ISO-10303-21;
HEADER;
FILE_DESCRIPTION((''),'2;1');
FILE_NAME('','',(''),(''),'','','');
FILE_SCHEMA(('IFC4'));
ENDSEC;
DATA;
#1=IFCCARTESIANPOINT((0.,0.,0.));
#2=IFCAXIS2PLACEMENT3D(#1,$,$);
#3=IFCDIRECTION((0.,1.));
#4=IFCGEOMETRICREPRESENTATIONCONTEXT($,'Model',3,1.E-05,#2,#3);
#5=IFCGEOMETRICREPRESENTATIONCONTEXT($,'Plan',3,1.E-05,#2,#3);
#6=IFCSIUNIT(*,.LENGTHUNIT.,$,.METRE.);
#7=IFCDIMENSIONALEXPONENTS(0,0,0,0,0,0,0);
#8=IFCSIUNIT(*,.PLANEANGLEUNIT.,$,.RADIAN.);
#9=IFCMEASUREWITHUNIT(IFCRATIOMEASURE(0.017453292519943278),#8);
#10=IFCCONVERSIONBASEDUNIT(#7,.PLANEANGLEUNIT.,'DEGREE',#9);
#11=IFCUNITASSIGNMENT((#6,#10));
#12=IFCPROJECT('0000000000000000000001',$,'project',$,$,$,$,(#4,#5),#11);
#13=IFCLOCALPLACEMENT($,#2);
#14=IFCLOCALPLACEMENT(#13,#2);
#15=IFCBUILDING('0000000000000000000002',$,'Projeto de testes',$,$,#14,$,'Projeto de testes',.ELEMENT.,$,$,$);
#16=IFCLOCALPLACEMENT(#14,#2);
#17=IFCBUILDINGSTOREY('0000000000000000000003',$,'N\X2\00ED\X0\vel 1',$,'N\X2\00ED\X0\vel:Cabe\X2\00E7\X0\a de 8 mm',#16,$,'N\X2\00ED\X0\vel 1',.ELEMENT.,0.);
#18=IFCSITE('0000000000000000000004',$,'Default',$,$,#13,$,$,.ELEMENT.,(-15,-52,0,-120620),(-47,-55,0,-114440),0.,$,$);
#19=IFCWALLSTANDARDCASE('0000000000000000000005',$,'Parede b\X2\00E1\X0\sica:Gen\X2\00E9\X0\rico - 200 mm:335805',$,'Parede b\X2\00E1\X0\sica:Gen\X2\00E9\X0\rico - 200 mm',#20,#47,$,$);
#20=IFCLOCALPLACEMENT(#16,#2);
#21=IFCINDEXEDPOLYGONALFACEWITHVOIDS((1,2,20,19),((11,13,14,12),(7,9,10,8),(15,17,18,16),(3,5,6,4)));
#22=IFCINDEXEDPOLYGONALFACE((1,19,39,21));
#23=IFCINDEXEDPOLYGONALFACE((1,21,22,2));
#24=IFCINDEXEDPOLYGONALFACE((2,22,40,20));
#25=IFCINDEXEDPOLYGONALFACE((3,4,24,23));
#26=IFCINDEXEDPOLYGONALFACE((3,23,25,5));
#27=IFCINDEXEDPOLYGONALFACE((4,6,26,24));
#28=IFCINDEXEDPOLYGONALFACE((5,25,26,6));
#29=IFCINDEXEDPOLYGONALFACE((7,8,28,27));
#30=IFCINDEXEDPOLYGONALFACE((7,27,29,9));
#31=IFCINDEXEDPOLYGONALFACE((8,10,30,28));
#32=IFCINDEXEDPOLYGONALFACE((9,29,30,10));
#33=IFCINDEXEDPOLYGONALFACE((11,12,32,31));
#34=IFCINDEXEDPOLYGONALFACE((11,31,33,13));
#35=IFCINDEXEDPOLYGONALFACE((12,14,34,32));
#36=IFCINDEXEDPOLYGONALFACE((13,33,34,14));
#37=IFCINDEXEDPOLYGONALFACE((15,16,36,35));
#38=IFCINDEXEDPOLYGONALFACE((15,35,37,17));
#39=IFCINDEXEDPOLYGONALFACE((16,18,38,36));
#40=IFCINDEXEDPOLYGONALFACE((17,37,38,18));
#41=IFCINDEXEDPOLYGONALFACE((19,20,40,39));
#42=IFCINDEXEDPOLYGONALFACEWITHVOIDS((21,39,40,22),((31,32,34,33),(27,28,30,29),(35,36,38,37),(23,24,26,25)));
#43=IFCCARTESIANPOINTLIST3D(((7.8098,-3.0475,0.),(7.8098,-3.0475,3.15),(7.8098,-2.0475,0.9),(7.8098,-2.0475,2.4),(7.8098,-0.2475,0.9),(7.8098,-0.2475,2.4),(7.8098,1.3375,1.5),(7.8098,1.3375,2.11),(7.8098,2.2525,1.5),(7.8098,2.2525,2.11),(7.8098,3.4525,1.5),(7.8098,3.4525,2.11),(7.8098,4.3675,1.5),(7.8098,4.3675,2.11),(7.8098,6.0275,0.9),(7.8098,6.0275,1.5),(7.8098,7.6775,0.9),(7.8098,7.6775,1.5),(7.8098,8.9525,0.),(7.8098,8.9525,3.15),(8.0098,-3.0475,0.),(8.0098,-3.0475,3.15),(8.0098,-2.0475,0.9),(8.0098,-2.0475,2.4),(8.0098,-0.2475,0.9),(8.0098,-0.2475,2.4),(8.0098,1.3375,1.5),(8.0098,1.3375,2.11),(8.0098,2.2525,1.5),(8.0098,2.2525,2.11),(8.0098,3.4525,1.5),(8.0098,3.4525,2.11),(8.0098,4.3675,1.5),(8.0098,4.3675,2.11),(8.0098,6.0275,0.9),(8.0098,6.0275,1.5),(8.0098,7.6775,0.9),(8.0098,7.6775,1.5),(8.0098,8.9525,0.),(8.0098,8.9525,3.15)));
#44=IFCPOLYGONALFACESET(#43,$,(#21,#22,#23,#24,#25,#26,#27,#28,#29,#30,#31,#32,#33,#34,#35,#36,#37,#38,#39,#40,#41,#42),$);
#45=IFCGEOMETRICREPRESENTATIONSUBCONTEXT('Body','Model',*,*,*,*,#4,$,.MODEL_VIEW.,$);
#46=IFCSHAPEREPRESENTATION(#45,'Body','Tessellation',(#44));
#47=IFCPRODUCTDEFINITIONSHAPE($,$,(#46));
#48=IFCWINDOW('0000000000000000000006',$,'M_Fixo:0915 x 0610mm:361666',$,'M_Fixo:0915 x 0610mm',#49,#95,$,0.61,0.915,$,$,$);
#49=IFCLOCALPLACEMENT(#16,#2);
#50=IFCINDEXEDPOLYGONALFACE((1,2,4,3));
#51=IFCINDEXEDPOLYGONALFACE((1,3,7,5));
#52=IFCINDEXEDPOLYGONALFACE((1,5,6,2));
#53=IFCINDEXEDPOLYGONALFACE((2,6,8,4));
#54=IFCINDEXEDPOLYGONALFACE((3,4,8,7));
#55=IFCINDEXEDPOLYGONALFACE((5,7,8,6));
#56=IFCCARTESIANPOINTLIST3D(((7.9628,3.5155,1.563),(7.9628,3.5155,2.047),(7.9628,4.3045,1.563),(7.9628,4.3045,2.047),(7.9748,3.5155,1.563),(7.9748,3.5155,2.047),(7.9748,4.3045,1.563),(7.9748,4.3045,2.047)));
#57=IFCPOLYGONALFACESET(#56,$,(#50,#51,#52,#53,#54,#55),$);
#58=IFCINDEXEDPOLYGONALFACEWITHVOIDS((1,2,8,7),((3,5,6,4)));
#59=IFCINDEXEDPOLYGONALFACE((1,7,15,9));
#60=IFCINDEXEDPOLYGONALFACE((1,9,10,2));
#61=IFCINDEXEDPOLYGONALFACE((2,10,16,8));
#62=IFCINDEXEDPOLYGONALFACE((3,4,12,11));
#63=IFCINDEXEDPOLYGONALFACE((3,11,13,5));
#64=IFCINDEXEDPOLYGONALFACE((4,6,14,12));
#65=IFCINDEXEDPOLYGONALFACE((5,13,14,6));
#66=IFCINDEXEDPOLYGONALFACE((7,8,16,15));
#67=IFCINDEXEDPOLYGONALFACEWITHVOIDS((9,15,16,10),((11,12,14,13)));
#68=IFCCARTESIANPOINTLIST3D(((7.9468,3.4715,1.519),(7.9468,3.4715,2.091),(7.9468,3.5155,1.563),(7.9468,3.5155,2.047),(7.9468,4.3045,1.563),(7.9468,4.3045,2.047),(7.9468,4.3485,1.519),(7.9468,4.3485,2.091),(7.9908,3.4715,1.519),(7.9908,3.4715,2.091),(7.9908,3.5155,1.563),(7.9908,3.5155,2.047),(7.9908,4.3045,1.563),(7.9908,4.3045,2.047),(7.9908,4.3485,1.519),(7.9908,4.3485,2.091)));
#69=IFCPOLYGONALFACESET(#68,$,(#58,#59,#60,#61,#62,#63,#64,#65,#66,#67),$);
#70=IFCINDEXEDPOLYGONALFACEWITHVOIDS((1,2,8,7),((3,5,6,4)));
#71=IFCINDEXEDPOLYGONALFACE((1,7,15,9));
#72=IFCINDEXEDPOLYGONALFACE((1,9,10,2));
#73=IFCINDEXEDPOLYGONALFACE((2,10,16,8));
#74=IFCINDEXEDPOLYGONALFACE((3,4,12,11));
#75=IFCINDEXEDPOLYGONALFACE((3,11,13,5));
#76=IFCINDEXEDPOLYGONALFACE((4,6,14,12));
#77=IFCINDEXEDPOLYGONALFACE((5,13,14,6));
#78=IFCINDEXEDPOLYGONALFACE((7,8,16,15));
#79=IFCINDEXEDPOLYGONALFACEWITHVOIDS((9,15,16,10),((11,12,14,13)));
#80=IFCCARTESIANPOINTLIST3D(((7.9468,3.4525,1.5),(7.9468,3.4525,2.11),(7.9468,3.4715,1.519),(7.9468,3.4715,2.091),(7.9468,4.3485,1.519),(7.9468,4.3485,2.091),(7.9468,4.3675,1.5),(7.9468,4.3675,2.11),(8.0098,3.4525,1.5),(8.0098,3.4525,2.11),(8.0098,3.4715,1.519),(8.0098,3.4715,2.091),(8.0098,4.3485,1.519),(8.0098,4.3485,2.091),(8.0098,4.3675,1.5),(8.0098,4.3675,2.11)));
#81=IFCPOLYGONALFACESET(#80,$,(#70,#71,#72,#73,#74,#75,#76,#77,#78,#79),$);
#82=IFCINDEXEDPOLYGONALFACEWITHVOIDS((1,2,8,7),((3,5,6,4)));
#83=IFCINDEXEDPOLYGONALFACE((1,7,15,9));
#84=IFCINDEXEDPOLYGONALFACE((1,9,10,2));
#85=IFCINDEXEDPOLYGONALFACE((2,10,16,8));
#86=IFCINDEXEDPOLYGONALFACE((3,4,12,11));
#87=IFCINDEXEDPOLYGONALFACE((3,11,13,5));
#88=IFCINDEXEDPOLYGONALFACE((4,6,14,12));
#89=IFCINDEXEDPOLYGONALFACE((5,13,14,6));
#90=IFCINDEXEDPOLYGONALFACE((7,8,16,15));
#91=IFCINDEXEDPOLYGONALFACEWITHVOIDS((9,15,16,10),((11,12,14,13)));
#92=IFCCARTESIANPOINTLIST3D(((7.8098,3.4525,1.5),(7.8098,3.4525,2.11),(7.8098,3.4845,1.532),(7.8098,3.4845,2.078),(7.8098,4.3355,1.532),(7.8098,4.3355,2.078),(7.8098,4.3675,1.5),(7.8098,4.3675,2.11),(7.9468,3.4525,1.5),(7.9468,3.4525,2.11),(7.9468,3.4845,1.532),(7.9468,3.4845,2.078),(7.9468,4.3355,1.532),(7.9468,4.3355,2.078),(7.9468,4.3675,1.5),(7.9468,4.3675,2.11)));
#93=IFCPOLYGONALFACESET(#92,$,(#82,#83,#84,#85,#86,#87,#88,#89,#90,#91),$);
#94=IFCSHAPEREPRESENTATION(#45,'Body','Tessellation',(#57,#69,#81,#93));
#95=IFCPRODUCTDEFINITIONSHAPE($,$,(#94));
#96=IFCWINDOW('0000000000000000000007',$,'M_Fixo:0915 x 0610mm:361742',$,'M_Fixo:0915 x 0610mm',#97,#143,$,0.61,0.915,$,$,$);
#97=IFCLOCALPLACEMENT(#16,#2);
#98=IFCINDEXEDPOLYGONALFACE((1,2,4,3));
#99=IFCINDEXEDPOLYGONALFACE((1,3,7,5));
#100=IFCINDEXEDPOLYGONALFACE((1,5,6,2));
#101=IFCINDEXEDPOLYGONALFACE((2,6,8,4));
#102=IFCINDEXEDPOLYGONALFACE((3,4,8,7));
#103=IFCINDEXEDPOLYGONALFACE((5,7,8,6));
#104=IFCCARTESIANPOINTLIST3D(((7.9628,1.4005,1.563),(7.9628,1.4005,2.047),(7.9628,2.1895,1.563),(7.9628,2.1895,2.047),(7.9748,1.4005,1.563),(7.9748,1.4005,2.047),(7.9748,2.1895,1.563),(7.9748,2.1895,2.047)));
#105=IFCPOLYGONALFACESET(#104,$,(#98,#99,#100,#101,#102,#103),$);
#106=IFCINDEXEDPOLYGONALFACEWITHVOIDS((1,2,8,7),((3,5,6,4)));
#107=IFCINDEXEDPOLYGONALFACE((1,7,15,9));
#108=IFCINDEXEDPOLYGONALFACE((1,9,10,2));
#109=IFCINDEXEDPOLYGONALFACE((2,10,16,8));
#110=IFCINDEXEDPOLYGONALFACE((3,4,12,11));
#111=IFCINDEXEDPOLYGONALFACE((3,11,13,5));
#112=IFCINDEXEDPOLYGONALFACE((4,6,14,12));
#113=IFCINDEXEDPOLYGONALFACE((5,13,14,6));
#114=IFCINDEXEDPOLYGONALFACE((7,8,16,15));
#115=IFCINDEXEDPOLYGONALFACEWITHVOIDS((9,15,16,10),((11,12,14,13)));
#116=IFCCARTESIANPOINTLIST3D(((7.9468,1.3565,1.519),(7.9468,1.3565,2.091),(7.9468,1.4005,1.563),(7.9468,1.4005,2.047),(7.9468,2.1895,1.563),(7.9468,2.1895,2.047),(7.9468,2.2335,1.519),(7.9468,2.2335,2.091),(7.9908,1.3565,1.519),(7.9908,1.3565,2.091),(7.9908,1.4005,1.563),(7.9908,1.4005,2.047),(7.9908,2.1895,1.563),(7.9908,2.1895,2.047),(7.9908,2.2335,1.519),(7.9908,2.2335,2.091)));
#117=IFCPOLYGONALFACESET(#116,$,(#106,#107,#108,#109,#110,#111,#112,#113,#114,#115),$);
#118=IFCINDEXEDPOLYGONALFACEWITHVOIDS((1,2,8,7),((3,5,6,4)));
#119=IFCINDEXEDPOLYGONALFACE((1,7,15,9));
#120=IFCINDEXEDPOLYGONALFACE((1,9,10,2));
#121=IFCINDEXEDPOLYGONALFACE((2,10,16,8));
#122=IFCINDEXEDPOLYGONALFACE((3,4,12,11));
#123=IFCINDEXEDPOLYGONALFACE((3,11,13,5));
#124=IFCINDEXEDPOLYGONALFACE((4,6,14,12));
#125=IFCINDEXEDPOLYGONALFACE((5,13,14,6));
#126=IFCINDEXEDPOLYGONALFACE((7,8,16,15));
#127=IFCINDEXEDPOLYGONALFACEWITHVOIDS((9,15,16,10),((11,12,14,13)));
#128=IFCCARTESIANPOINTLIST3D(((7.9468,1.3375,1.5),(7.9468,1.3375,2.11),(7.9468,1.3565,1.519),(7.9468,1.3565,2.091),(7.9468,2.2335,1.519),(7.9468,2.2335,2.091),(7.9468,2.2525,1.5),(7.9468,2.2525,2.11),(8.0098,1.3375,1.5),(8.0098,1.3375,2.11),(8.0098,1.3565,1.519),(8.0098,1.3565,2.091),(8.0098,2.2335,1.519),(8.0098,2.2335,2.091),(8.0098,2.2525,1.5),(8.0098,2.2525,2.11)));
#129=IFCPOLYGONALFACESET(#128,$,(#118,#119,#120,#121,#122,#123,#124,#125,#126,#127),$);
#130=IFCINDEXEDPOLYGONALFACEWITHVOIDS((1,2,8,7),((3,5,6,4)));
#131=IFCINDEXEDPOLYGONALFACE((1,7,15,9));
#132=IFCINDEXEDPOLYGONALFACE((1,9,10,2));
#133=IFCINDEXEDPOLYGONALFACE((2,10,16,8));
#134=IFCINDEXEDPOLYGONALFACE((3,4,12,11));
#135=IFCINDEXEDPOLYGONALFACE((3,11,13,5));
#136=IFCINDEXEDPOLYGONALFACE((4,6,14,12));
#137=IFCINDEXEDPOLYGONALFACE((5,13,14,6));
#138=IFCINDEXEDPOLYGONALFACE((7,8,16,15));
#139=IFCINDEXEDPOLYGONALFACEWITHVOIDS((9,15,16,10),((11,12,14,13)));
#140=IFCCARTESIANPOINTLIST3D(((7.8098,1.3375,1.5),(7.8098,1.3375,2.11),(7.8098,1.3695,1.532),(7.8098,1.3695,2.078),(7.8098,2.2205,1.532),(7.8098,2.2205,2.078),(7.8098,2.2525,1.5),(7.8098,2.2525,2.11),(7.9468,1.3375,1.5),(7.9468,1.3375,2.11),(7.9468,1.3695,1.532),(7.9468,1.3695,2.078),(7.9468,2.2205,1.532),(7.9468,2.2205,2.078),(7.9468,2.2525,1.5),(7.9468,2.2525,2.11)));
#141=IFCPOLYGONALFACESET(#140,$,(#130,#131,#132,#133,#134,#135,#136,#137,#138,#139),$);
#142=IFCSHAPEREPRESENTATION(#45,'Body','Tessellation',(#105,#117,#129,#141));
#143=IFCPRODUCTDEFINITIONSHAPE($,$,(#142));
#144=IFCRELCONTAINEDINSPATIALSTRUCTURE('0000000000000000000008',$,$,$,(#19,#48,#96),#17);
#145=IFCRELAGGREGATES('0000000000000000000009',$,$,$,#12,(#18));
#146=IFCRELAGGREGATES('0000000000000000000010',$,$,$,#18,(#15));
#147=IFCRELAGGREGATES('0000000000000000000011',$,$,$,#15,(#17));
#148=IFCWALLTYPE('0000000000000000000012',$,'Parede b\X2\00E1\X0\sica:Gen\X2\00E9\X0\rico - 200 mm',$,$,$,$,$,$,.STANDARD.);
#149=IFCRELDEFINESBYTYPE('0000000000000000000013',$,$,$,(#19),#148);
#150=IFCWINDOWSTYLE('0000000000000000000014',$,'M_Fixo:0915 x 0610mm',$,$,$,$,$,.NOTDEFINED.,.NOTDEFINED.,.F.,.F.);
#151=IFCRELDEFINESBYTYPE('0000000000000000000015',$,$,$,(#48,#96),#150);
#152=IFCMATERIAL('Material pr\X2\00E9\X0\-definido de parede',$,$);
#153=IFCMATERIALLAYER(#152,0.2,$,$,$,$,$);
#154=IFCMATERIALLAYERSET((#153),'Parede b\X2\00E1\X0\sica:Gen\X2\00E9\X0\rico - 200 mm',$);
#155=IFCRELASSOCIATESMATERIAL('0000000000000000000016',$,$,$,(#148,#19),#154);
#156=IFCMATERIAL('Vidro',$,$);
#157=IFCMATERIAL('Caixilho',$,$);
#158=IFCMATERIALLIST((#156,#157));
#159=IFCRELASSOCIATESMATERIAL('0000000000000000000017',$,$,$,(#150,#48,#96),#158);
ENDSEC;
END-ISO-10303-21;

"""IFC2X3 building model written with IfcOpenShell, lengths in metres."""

from ifc_helpers import new_model, entity, si_unit, converted_unit, direction, frame, frame_2d, origin, place, context, subcontext, project, spatial, polyline, rectangle, outline, extrude, source, transform, mapped, material, material_list, layer, layer_set, layer_usage, type_object, type_shapes, element, fill, save


model = new_model("IFC2X3")

# Units and contexts
model_context = context("Model", 3, precision=1e-05, world=origin(), true_north=direction((0.0, 1.0)))
plan_context = context("Plan", 3, precision=1e-05, world=origin(), true_north=direction((0.0, 1.0)))
body_context = subcontext(model_context, "Body", "Model", "MODEL_VIEW")
ifc_project = project(units=[si_unit("LENGTHUNIT", "METRE"), converted_unit("PLANEANGLEUNIT", "DEGREE", entity("IfcRatioMeasure", 0.017453292519943278), si_unit("PLANEANGLEUNIT", "RADIAN"), dimensions=[0, 0, 0, 0, 0, 0, 0])], contexts=[model_context, plan_context])

# Site, building, storey
site_placement = place(None, origin())
site = spatial("IfcSite", under=ifc_project, at=site_placement, Name="Default", CompositionType="ELEMENT", RefLatitude=(-15, -52, 0, -120620), RefLongitude=(-47, -55, 0, -114440), RefElevation=0.0)
building_placement = place(site_placement, origin())
building = spatial("IfcBuilding", under=site, at=building_placement, Name="Projeto de testes", LongName="Projeto de testes", CompositionType="ELEMENT")
storey_placement = place(building_placement, origin())
storey = spatial("IfcBuildingStorey", under=building, at=storey_placement, Name="Nível 1", ObjectType="Nível:Cabeça de 8 mm", LongName="Nível 1", CompositionType="ELEMENT", Elevation=0.0)

# Wall, openings, windows
ifc_material_1 = material(Name="Material pré-definido de parede")
ifc_layer = layer(ifc_material_1, 0.2)
ifc_layer_set = layer_set([ifc_layer], Name="Parede básica:Genérico - 200 mm")
ifc_layer_usage_1 = layer_usage(ifc_layer_set, "AXIS2", "POSITIVE", -0.1)
wall_type = type_object("IfcWallType", Name="Parede básica:Genérico - 200 mm", PredefinedType="STANDARD", material=ifc_layer_set)
wall_1_placement = place(storey_placement, frame((7.9098, -3.0475, 0.0), z_axis=(0.0, 0.0, 1.0), x_axis=(0.0, 1.0, 0.0)))
wall_1 = element("IfcWallStandardCase", 1, at=wall_1_placement, inside=storey, type_object=wall_type, material=ifc_layer_usage_1, Name="Parede básica:Genérico - 200 mm:335805", ObjectType="Parede básica:Genérico - 200 mm", context=body_context, shape_type="SweptSolid", body=[
    extrude(rectangle(XDim=12.0, YDim=0.2, at=frame_2d((6.0, 0.0), x_axis=(-1.0, 0.0))), origin(), (0.0, 0.0, 1.0), 3.15),
])
opening_1_placement = place(wall_1_placement, frame((10.725, 0.1, 0.9)))
element("IfcOpeningElement", 2, at=opening_1_placement, cuts=wall_1, ObjectType="Opening", context=body_context, shape_type="SweptSolid", body=[
    extrude(rectangle(XDim=0.6, YDim=1.65, at=frame_2d((0.3, 0.825), x_axis=(-1.0, 0.0))), frame((0.0, 0.0, 0.0), z_axis=(0.0, -1.0, 0.0), x_axis=(0.0, 0.0, 1.0)), (0.0, 0.0, 1.0), 0.2),
])
opening_2_placement = place(wall_1_placement, frame((2.8, 0.1, 0.9)))
element("IfcOpeningElement", 3, at=opening_2_placement, cuts=wall_1, ObjectType="Opening", context=body_context, shape_type="SweptSolid", body=[
    extrude(rectangle(XDim=1.5, YDim=1.8, at=frame_2d((0.75, 0.9), x_axis=(-1.0, 0.0))), frame((0.0, 0.0, 0.0), z_axis=(0.0, -1.0, 0.0), x_axis=(0.0, 0.0, 1.0)), (0.0, 0.0, 1.0), 0.2),
])
opening_3_placement = place(wall_1_placement, frame((7.415, 0.1, 1.5)))
opening_3 = element("IfcOpeningElement", 4, at=opening_3_placement, cuts=wall_1, ObjectType="Opening", context=body_context, shape_type="SweptSolid", body=[
    extrude(rectangle(XDim=0.61, YDim=0.915, at=frame_2d((0.305, 0.4575), x_axis=(1.0, 0.0))), frame((0.0, 0.0, 0.0), z_axis=(0.0, -1.0, 0.0), x_axis=(0.0, 0.0, 1.0)), (0.0, 0.0, 1.0), 0.2),
])
opening_4_placement = place(wall_1_placement, frame((5.3, 0.1, 1.5)))
opening_4 = element("IfcOpeningElement", 5, at=opening_4_placement, cuts=wall_1, ObjectType="Opening", context=body_context, shape_type="SweptSolid", body=[
    extrude(rectangle(XDim=0.61, YDim=0.915, at=frame_2d((0.305, 0.4575), x_axis=(1.0, 0.0))), frame((0.0, 0.0, 0.0), z_axis=(0.0, -1.0, 0.0), x_axis=(0.0, 0.0, 1.0)), (0.0, 0.0, 1.0), 0.2),
])
ifc_material_2 = material(Name="Vidro")
ifc_material_3 = material(Name="Caixilho")
ifc_material_list_1 = material_list([ifc_material_2, ifc_material_3])
window_style = type_object("IfcWindowStyle", Name="M_Fixo:0915 x 0610mm", ConstructionType="NOTDEFINED", OperationType="NOTDEFINED", ParameterTakesPrecedence=False, Sizeable=False, material=ifc_material_list_1)
shared_shape_1 = source(origin(), body_context, "Body", "SweptSolid", [
    extrude(rectangle(XDim=0.012, YDim=0.789, at=frame_2d((0.0, 0.0), x_axis=(1.0, 0.0))), frame((0.4575, 0.159, 0.063), z_axis=(0.0, 0.0, 1.0), x_axis=(0.0, -1.0, 0.0)), (0.0, 0.0, 1.0), 0.484),
    extrude(outline(polyline([(-0.4385, -0.286), (0.4385, -0.286), (0.4385, 0.286), (-0.4385, 0.286), (-0.4385, -0.286)]), holes=[polyline([(-0.3945, -0.242), (-0.3945, 0.242), (0.3945, 0.242), (0.3945, -0.242), (-0.3945, -0.242)])]), frame((0.4575, 0.137, 0.305), z_axis=(0.0, 1.0, 0.0), x_axis=(1.0, 0.0, 0.0)), (0.0, 0.0, 1.0), 0.044),
    extrude(outline(polyline([(-0.4575, -0.305), (0.4575, -0.305), (0.4575, 0.305), (-0.4575, 0.305), (-0.4575, -0.305)]), holes=[polyline([(-0.4385, -0.286), (-0.4385, 0.286), (0.4385, 0.286), (0.4385, -0.286), (-0.4385, -0.286)])]), frame((0.4575, 0.137, 0.305), z_axis=(0.0, 1.0, 0.0), x_axis=(1.0, 0.0, 0.0)), (0.0, 0.0, 1.0), 0.063),
    extrude(outline(polyline([(-0.4575, -0.305), (0.4575, -0.305), (0.4575, 0.305), (-0.4575, 0.305), (-0.4575, -0.305)]), holes=[polyline([(-0.4255, -0.273), (-0.4255, 0.273), (0.4255, 0.273), (0.4255, -0.273), (-0.4255, -0.273)])]), frame((0.4575, 0.0, 0.305), z_axis=(0.0, 1.0, 0.0), x_axis=(1.0, 0.0, 0.0)), (0.0, 0.0, 1.0), 0.137),
])
type_shapes(window_style, [shared_shape_1])
window_1_placement = place(opening_3_placement, frame((0.0, 0.0, 0.0), z_axis=(0.0, 0.0, 1.0), x_axis=(-1.0, 0.0, 0.0)))
window_1 = element("IfcWindow", 6, at=window_1_placement, inside=storey, type_object=window_style, material=ifc_material_list_1, Name="M_Fixo:0915 x 0610mm:361666", ObjectType="M_Fixo:0915 x 0610mm", OverallHeight=0.61, OverallWidth=0.915, context=body_context, shape_type="MappedRepresentation", body=[
    mapped(shared_shape_1, transform((0.0, 0.0, 0.0), scale=1.0)),
])
fill(opening_3, window_1)
window_2_placement = place(opening_4_placement, frame((0.0, 0.0, 0.0), z_axis=(0.0, 0.0, 1.0), x_axis=(-1.0, 0.0, 0.0)))
window_2 = element("IfcWindow", 7, at=window_2_placement, inside=storey, type_object=window_style, material=ifc_material_list_1, Name="M_Fixo:0915 x 0610mm:361742", ObjectType="M_Fixo:0915 x 0610mm", OverallHeight=0.61, OverallWidth=0.915, context=body_context, shape_type="MappedRepresentation", body=[
    mapped(shared_shape_1, transform((0.0, 0.0, 0.0), scale=1.0)),
])
fill(opening_4, window_2)

save(model, "model.ifc")
